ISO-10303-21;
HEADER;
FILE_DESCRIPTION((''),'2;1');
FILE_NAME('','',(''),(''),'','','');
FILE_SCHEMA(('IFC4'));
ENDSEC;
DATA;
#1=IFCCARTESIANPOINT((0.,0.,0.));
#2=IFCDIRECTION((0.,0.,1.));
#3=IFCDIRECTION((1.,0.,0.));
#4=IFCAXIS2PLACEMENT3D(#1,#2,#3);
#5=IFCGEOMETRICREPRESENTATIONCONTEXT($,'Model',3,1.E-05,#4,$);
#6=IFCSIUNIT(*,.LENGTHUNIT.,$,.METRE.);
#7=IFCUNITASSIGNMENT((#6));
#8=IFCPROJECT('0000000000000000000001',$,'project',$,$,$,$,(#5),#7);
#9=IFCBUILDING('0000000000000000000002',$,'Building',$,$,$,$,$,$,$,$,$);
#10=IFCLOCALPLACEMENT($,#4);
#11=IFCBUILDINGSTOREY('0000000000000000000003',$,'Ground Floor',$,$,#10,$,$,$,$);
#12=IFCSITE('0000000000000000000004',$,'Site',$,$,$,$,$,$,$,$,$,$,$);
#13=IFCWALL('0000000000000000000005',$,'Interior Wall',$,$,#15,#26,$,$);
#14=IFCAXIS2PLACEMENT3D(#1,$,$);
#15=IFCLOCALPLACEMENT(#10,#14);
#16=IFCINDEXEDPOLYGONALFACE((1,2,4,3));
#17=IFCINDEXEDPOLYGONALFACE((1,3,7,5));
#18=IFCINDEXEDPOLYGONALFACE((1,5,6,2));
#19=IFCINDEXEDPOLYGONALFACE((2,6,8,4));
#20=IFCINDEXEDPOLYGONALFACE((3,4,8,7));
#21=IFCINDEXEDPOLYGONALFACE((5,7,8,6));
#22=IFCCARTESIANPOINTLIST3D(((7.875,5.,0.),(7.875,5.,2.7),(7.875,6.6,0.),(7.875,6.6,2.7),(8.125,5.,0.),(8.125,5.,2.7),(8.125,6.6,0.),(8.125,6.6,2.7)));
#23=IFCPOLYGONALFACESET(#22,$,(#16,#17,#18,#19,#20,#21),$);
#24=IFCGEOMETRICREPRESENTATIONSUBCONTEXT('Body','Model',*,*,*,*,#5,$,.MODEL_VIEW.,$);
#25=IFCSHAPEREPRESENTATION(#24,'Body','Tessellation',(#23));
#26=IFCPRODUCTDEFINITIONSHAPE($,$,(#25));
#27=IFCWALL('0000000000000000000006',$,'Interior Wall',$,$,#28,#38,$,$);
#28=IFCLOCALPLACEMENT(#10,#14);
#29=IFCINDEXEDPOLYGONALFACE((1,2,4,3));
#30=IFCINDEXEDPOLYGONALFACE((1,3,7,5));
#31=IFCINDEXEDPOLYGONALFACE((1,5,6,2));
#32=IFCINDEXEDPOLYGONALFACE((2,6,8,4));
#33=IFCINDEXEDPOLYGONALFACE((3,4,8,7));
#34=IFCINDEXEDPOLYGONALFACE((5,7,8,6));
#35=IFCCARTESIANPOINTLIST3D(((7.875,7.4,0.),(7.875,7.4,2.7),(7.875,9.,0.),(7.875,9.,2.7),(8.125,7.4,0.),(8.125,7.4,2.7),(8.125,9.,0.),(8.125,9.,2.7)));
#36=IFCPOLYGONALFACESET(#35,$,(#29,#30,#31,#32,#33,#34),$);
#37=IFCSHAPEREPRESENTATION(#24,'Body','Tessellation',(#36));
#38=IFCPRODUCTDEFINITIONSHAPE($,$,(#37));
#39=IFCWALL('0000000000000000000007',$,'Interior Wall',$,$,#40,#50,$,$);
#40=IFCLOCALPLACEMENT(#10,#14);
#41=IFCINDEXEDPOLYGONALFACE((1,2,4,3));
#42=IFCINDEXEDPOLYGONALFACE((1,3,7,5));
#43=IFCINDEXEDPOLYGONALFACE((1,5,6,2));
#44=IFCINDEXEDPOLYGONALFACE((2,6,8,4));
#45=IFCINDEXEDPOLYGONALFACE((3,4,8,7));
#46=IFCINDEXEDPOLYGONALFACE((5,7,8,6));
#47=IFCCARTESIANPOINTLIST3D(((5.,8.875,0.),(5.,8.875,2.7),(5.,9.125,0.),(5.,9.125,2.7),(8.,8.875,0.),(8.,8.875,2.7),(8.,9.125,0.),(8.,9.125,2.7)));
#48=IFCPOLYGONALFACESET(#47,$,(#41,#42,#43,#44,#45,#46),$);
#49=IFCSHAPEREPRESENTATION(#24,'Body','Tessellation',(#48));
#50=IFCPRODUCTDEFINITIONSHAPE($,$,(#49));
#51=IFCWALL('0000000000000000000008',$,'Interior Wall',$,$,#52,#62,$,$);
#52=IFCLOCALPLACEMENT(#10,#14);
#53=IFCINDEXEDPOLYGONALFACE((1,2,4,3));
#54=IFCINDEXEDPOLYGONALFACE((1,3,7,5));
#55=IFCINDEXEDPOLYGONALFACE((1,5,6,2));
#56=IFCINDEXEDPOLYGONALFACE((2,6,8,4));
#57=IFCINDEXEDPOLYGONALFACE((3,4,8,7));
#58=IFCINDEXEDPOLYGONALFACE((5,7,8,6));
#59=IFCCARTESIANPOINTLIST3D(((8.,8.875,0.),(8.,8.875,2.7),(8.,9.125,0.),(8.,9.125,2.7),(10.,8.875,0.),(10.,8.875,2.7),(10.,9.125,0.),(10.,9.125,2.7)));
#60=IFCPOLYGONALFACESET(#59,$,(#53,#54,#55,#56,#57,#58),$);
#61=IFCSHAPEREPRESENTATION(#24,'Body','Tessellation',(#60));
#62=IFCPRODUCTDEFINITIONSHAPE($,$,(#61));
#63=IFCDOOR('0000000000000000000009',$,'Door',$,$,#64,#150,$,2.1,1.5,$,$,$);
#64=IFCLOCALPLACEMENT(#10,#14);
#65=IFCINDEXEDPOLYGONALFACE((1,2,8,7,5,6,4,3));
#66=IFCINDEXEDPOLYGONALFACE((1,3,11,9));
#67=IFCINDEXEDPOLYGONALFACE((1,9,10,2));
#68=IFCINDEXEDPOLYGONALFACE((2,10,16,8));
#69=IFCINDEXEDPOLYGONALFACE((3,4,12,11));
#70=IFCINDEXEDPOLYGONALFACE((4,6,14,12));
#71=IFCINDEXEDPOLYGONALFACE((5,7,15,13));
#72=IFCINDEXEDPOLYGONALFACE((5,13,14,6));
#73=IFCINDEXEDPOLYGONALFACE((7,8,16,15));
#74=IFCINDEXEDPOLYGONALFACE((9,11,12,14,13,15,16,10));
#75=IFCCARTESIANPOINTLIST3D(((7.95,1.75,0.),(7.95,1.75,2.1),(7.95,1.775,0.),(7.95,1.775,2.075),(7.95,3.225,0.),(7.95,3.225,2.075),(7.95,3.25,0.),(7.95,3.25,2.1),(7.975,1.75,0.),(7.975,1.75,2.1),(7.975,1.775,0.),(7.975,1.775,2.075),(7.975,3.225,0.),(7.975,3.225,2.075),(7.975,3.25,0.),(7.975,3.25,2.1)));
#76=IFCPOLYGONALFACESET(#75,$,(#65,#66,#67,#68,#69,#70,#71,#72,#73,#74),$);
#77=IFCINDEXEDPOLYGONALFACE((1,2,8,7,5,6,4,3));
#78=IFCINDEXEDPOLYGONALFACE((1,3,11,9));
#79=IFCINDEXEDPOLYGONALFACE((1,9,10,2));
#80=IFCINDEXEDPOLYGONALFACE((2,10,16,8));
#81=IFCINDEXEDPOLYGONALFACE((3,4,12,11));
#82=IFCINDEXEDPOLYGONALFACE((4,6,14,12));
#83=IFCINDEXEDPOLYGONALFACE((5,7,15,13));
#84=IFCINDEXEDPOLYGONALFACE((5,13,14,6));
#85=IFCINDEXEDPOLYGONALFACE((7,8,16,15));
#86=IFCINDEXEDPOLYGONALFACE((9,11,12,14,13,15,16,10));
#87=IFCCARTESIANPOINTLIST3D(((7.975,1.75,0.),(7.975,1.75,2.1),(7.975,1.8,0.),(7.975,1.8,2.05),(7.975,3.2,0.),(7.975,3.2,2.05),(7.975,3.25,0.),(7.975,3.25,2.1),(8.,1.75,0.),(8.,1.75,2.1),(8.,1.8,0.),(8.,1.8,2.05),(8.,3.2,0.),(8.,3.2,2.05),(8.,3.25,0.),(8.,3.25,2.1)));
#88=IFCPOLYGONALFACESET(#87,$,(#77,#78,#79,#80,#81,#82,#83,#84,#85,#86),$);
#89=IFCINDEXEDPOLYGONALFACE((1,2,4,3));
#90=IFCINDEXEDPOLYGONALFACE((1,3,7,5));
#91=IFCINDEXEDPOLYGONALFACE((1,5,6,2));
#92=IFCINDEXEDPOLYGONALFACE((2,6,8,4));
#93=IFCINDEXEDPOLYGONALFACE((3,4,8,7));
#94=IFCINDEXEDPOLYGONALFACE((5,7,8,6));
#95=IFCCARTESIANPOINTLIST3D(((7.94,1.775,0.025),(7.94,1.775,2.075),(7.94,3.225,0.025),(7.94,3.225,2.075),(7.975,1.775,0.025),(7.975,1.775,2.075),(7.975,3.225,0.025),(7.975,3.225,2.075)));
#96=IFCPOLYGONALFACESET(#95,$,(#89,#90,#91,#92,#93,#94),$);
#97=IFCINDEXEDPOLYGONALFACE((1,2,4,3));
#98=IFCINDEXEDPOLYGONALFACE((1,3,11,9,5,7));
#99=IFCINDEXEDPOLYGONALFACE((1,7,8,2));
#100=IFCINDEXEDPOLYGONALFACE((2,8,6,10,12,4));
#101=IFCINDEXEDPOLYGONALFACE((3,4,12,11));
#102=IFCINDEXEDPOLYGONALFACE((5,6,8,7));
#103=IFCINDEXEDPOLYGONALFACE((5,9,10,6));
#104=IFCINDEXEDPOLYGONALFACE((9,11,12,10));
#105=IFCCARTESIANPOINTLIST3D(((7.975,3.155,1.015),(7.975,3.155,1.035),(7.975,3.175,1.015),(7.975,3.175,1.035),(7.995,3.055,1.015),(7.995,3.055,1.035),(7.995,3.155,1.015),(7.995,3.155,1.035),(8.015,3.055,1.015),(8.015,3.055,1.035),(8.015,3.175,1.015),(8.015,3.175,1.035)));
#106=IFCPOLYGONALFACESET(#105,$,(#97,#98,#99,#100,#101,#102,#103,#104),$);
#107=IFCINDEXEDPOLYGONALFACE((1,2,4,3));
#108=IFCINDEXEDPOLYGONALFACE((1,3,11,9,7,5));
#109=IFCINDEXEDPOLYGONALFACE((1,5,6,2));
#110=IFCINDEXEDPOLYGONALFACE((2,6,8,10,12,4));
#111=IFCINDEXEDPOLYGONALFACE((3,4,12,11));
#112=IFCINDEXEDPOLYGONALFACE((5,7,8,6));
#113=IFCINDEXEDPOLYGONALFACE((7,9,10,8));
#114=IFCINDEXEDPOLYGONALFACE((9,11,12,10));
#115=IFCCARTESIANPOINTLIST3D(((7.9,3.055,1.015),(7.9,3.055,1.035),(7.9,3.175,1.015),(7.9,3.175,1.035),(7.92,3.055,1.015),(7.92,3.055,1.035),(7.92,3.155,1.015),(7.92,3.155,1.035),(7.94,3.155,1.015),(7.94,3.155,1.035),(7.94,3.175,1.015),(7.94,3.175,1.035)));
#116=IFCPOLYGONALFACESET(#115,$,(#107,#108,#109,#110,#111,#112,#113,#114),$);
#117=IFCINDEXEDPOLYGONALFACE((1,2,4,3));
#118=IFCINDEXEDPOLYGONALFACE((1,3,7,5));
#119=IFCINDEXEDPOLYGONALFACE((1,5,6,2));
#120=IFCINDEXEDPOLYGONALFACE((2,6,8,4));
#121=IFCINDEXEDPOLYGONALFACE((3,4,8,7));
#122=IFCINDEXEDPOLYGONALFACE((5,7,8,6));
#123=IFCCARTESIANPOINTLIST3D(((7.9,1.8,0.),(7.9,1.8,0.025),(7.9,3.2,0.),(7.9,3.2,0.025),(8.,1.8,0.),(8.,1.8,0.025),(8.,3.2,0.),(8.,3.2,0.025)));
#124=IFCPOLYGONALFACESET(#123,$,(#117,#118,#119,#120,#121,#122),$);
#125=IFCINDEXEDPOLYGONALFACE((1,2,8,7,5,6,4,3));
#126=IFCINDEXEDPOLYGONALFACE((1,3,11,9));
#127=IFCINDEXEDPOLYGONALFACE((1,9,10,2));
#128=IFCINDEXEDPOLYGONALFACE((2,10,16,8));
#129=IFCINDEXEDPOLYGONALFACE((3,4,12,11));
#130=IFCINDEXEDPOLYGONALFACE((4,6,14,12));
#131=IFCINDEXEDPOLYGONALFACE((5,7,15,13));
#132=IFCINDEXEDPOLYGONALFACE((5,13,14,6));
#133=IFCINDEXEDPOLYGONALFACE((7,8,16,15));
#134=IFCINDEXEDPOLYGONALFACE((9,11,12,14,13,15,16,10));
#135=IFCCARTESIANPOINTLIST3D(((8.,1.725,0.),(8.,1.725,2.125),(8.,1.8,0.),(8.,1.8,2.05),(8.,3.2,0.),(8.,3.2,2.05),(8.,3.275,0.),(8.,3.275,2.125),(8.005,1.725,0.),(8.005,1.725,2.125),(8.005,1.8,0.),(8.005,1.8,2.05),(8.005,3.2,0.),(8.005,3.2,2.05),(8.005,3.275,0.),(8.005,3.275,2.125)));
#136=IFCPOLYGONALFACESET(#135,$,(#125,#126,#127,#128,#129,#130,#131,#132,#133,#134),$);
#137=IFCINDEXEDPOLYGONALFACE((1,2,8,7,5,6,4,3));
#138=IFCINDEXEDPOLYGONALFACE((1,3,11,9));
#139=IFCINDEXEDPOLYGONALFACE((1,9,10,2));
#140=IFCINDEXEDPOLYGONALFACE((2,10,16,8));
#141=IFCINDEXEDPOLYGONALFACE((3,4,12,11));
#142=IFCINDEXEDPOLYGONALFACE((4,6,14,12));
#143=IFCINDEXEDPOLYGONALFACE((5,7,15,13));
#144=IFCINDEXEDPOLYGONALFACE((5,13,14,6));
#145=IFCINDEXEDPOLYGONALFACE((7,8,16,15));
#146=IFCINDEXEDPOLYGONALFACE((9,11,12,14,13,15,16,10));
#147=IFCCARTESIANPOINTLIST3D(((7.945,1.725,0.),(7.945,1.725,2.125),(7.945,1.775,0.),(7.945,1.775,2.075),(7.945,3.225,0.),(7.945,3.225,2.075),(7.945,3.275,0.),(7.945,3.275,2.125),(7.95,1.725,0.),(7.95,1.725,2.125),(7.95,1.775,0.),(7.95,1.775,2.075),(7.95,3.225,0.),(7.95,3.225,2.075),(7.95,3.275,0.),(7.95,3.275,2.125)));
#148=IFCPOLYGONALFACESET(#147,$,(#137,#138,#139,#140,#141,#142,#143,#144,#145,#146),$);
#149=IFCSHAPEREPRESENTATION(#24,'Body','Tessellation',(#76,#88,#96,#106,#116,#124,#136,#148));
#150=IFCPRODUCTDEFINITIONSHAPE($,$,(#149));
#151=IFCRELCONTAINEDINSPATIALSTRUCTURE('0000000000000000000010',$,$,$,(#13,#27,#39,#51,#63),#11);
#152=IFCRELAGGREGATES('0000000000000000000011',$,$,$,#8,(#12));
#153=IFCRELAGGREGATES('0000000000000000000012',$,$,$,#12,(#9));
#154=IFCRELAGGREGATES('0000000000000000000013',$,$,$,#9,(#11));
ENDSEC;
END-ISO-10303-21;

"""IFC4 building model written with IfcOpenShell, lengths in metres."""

from ifc_helpers import new_model, si_unit, frame, origin_with_axes, place, context, subcontext, project, spatial, line, indexed_curve, outline, extrude, element, save


model = new_model("IFC4")

# Units and contexts
model_context = context("Model", 3, precision=1e-05, world=origin_with_axes())
body_context = subcontext(model_context, "Body", "Model", "MODEL_VIEW")
ifc_project = project(units=[si_unit("LENGTHUNIT", "METRE")], contexts=[model_context])

# Site, building, storey
site = spatial("IfcSite", under=ifc_project, Name="Site")
building = spatial("IfcBuilding", under=site, Name="Building")
storey_placement = place(None, origin_with_axes())
storey = spatial("IfcBuildingStorey", under=building, at=storey_placement, Name="Ground Floor")

# Walls
for number, where, z_axis, x_axis, name in (
    (1, (8.0, 5.0, 0.0), (0.0, 0.0, 1.0), (0.0, 1.0, 0.0), "Interior Wall"),
    (2, (8.0, 7.4, 0.0), (0.0, 0.0, 1.0), (0.0, 1.0, 0.0), "Interior Wall"),
):
    element("IfcWall", number, at=place(storey_placement, frame(where, z_axis=z_axis, x_axis=x_axis)), inside=storey, Name=name, context=body_context, shape_type="SweptSolid", body=[
        extrude(outline(indexed_curve([(0.0, 0.0), (0.0, 0.25), (1.6, 0.25), (1.6, 0.0), (0.0, 0.0)], self_intersect=False)), frame((0.0, -0.125, 0.0), z_axis=(0.0, 0.0, 1.0), x_axis=(1.0, 0.0, 0.0)), (0.0, 0.0, 1.0), 2.7),
    ])
wall_1_placement = place(storey_placement, frame((8.0, 9.0, 0.0), z_axis=(0.0, 0.0, 1.0), x_axis=(-1.0, 0.0, 0.0)))
element("IfcWall", 3, at=wall_1_placement, inside=storey, Name="Interior Wall", context=body_context, shape_type="SweptSolid", body=[
    extrude(outline(indexed_curve([(0.0, 0.0), (0.0, 0.25), (3.0, 0.25), (3.0, 0.0), (0.0, 0.0)], self_intersect=False)), frame((0.0, -0.125, 0.0), z_axis=(0.0, 0.0, 1.0), x_axis=(1.0, 0.0, 0.0)), (0.0, 0.0, 1.0), 2.7),
])
wall_2_placement = place(storey_placement, frame((10.0, 9.0, 0.0), z_axis=(0.0, 0.0, 1.0), x_axis=(-1.0, 0.0, 0.0)))
element("IfcWall", 4, at=wall_2_placement, inside=storey, Name="Interior Wall", context=body_context, shape_type="SweptSolid", body=[
    extrude(outline(indexed_curve([(0.0, 0.0), (0.0, 0.25), (2.0, 0.25), (2.0, 0.0), (0.0, 0.0)], self_intersect=False)), frame((0.0, -0.125, 0.0), z_axis=(0.0, 0.0, 1.0), x_axis=(1.0, 0.0, 0.0)), (0.0, 0.0, 1.0), 2.7),
])

# Door
door_1_placement = place(storey_placement, frame((8.0, 1.75, 0.0), z_axis=(0.0, 0.0, 1.0), x_axis=(0.0, 1.0, 0.0)))
element("IfcDoor", 5, at=door_1_placement, inside=storey, Name="Door", OverallHeight=2.1, OverallWidth=1.5, context=body_context, shape_type="SweptSolid", body=[
    extrude(outline(indexed_curve([(0.0, 0.0), (0.0, 2.1), (1.5, 2.1), (1.5, 0.0), (1.475, 0.0), (1.475, 2.075), (0.025, 2.075), (0.025, 0.0)], segments=[line(1, 2, 3, 4, 5, 6, 7, 8, 1)])), frame((0.0, 0.025, 0.0), z_axis=(0.0, -1.0, 0.0), x_axis=(1.0, 0.0, 0.0)), (0.0, 0.0, -1.0), 0.025),
    extrude(outline(indexed_curve([(0.0, 0.0), (0.0, 2.1), (1.5, 2.1), (1.5, 0.0), (1.45, 0.0), (1.45, 2.05), (0.05, 2.05), (0.05, 0.0)], segments=[line(1, 2, 3, 4, 5, 6, 7, 8, 1)])), frame((0.0, 0.0, 0.0), z_axis=(0.0, -1.0, 0.0), x_axis=(1.0, 0.0, 0.0)), (0.0, 0.0, -1.0), 0.025),
    extrude(outline(indexed_curve([(0.0, 0.0), (1.45, 0.0), (1.45, 0.035), (0.0, 0.035)], segments=[line(1, 2, 3, 4, 1)])), frame((0.025, 0.025, 0.025), z_axis=(0.0, 0.0, 1.0), x_axis=(1.0, 0.0, 0.0)), (0.0, 0.0, 1.0), 2.05),
    extrude(outline(indexed_curve([(0.0, 0.0), (0.0, -0.04), (-0.12, -0.04), (-0.12, -0.02), (-0.02, -0.02), (-0.02, 0.0)], segments=[line(1, 2, 3, 4, 5, 6, 1)])), frame((1.425, 0.025, 1.015), z_axis=(0.0, 0.0, 1.0), x_axis=(1.0, 0.0, 0.0)), (0.0, 0.0, 1.0), 0.02),
    extrude(outline(indexed_curve([(0.0, 0.0), (0.0, 0.04), (-0.12, 0.04), (-0.12, 0.02), (-0.02, 0.02), (-0.02, 0.0)], segments=[line(1, 2, 3, 4, 5, 6, 1)])), frame((1.425, 0.06, 1.015), z_axis=(0.0, 0.0, 1.0), x_axis=(1.0, 0.0, 0.0)), (0.0, 0.0, 1.0), 0.02),
    extrude(outline(indexed_curve([(0.0, 0.0), (1.4, 0.0), (1.4, 0.1), (0.0, 0.1)], segments=[line(1, 2, 3, 4, 1)])), frame((0.05, 0.0, 0.0), z_axis=(0.0, 0.0, 1.0), x_axis=(1.0, 0.0, 0.0)), (0.0, 0.0, 1.0), 0.025),
    extrude(outline(indexed_curve([(0.0, 0.0), (0.0, 2.125), (1.55, 2.125), (1.55, 0.0), (1.475, 0.0), (1.475, 2.05), (0.075, 2.05), (0.075, 0.0)], segments=[line(1, 2, 3, 4, 5, 6, 7, 8, 1)])), frame((-0.025, -0.005, 0.0), z_axis=(0.0, -1.0, 0.0), x_axis=(1.0, 0.0, 0.0)), (0.0, 0.0, -1.0), 0.005),
    extrude(outline(indexed_curve([(0.0, 0.0), (0.0, 2.125), (1.55, 2.125), (1.55, 0.0), (1.5, 0.0), (1.5, 2.075), (0.05, 2.075), (0.05, 0.0)], segments=[line(1, 2, 3, 4, 5, 6, 7, 8, 1)])), frame((-0.025, 0.05, 0.0), z_axis=(0.0, -1.0, 0.0), x_axis=(1.0, 0.0, 0.0)), (0.0, 0.0, -1.0), 0.005),
])

save(model, "model.ifc")
